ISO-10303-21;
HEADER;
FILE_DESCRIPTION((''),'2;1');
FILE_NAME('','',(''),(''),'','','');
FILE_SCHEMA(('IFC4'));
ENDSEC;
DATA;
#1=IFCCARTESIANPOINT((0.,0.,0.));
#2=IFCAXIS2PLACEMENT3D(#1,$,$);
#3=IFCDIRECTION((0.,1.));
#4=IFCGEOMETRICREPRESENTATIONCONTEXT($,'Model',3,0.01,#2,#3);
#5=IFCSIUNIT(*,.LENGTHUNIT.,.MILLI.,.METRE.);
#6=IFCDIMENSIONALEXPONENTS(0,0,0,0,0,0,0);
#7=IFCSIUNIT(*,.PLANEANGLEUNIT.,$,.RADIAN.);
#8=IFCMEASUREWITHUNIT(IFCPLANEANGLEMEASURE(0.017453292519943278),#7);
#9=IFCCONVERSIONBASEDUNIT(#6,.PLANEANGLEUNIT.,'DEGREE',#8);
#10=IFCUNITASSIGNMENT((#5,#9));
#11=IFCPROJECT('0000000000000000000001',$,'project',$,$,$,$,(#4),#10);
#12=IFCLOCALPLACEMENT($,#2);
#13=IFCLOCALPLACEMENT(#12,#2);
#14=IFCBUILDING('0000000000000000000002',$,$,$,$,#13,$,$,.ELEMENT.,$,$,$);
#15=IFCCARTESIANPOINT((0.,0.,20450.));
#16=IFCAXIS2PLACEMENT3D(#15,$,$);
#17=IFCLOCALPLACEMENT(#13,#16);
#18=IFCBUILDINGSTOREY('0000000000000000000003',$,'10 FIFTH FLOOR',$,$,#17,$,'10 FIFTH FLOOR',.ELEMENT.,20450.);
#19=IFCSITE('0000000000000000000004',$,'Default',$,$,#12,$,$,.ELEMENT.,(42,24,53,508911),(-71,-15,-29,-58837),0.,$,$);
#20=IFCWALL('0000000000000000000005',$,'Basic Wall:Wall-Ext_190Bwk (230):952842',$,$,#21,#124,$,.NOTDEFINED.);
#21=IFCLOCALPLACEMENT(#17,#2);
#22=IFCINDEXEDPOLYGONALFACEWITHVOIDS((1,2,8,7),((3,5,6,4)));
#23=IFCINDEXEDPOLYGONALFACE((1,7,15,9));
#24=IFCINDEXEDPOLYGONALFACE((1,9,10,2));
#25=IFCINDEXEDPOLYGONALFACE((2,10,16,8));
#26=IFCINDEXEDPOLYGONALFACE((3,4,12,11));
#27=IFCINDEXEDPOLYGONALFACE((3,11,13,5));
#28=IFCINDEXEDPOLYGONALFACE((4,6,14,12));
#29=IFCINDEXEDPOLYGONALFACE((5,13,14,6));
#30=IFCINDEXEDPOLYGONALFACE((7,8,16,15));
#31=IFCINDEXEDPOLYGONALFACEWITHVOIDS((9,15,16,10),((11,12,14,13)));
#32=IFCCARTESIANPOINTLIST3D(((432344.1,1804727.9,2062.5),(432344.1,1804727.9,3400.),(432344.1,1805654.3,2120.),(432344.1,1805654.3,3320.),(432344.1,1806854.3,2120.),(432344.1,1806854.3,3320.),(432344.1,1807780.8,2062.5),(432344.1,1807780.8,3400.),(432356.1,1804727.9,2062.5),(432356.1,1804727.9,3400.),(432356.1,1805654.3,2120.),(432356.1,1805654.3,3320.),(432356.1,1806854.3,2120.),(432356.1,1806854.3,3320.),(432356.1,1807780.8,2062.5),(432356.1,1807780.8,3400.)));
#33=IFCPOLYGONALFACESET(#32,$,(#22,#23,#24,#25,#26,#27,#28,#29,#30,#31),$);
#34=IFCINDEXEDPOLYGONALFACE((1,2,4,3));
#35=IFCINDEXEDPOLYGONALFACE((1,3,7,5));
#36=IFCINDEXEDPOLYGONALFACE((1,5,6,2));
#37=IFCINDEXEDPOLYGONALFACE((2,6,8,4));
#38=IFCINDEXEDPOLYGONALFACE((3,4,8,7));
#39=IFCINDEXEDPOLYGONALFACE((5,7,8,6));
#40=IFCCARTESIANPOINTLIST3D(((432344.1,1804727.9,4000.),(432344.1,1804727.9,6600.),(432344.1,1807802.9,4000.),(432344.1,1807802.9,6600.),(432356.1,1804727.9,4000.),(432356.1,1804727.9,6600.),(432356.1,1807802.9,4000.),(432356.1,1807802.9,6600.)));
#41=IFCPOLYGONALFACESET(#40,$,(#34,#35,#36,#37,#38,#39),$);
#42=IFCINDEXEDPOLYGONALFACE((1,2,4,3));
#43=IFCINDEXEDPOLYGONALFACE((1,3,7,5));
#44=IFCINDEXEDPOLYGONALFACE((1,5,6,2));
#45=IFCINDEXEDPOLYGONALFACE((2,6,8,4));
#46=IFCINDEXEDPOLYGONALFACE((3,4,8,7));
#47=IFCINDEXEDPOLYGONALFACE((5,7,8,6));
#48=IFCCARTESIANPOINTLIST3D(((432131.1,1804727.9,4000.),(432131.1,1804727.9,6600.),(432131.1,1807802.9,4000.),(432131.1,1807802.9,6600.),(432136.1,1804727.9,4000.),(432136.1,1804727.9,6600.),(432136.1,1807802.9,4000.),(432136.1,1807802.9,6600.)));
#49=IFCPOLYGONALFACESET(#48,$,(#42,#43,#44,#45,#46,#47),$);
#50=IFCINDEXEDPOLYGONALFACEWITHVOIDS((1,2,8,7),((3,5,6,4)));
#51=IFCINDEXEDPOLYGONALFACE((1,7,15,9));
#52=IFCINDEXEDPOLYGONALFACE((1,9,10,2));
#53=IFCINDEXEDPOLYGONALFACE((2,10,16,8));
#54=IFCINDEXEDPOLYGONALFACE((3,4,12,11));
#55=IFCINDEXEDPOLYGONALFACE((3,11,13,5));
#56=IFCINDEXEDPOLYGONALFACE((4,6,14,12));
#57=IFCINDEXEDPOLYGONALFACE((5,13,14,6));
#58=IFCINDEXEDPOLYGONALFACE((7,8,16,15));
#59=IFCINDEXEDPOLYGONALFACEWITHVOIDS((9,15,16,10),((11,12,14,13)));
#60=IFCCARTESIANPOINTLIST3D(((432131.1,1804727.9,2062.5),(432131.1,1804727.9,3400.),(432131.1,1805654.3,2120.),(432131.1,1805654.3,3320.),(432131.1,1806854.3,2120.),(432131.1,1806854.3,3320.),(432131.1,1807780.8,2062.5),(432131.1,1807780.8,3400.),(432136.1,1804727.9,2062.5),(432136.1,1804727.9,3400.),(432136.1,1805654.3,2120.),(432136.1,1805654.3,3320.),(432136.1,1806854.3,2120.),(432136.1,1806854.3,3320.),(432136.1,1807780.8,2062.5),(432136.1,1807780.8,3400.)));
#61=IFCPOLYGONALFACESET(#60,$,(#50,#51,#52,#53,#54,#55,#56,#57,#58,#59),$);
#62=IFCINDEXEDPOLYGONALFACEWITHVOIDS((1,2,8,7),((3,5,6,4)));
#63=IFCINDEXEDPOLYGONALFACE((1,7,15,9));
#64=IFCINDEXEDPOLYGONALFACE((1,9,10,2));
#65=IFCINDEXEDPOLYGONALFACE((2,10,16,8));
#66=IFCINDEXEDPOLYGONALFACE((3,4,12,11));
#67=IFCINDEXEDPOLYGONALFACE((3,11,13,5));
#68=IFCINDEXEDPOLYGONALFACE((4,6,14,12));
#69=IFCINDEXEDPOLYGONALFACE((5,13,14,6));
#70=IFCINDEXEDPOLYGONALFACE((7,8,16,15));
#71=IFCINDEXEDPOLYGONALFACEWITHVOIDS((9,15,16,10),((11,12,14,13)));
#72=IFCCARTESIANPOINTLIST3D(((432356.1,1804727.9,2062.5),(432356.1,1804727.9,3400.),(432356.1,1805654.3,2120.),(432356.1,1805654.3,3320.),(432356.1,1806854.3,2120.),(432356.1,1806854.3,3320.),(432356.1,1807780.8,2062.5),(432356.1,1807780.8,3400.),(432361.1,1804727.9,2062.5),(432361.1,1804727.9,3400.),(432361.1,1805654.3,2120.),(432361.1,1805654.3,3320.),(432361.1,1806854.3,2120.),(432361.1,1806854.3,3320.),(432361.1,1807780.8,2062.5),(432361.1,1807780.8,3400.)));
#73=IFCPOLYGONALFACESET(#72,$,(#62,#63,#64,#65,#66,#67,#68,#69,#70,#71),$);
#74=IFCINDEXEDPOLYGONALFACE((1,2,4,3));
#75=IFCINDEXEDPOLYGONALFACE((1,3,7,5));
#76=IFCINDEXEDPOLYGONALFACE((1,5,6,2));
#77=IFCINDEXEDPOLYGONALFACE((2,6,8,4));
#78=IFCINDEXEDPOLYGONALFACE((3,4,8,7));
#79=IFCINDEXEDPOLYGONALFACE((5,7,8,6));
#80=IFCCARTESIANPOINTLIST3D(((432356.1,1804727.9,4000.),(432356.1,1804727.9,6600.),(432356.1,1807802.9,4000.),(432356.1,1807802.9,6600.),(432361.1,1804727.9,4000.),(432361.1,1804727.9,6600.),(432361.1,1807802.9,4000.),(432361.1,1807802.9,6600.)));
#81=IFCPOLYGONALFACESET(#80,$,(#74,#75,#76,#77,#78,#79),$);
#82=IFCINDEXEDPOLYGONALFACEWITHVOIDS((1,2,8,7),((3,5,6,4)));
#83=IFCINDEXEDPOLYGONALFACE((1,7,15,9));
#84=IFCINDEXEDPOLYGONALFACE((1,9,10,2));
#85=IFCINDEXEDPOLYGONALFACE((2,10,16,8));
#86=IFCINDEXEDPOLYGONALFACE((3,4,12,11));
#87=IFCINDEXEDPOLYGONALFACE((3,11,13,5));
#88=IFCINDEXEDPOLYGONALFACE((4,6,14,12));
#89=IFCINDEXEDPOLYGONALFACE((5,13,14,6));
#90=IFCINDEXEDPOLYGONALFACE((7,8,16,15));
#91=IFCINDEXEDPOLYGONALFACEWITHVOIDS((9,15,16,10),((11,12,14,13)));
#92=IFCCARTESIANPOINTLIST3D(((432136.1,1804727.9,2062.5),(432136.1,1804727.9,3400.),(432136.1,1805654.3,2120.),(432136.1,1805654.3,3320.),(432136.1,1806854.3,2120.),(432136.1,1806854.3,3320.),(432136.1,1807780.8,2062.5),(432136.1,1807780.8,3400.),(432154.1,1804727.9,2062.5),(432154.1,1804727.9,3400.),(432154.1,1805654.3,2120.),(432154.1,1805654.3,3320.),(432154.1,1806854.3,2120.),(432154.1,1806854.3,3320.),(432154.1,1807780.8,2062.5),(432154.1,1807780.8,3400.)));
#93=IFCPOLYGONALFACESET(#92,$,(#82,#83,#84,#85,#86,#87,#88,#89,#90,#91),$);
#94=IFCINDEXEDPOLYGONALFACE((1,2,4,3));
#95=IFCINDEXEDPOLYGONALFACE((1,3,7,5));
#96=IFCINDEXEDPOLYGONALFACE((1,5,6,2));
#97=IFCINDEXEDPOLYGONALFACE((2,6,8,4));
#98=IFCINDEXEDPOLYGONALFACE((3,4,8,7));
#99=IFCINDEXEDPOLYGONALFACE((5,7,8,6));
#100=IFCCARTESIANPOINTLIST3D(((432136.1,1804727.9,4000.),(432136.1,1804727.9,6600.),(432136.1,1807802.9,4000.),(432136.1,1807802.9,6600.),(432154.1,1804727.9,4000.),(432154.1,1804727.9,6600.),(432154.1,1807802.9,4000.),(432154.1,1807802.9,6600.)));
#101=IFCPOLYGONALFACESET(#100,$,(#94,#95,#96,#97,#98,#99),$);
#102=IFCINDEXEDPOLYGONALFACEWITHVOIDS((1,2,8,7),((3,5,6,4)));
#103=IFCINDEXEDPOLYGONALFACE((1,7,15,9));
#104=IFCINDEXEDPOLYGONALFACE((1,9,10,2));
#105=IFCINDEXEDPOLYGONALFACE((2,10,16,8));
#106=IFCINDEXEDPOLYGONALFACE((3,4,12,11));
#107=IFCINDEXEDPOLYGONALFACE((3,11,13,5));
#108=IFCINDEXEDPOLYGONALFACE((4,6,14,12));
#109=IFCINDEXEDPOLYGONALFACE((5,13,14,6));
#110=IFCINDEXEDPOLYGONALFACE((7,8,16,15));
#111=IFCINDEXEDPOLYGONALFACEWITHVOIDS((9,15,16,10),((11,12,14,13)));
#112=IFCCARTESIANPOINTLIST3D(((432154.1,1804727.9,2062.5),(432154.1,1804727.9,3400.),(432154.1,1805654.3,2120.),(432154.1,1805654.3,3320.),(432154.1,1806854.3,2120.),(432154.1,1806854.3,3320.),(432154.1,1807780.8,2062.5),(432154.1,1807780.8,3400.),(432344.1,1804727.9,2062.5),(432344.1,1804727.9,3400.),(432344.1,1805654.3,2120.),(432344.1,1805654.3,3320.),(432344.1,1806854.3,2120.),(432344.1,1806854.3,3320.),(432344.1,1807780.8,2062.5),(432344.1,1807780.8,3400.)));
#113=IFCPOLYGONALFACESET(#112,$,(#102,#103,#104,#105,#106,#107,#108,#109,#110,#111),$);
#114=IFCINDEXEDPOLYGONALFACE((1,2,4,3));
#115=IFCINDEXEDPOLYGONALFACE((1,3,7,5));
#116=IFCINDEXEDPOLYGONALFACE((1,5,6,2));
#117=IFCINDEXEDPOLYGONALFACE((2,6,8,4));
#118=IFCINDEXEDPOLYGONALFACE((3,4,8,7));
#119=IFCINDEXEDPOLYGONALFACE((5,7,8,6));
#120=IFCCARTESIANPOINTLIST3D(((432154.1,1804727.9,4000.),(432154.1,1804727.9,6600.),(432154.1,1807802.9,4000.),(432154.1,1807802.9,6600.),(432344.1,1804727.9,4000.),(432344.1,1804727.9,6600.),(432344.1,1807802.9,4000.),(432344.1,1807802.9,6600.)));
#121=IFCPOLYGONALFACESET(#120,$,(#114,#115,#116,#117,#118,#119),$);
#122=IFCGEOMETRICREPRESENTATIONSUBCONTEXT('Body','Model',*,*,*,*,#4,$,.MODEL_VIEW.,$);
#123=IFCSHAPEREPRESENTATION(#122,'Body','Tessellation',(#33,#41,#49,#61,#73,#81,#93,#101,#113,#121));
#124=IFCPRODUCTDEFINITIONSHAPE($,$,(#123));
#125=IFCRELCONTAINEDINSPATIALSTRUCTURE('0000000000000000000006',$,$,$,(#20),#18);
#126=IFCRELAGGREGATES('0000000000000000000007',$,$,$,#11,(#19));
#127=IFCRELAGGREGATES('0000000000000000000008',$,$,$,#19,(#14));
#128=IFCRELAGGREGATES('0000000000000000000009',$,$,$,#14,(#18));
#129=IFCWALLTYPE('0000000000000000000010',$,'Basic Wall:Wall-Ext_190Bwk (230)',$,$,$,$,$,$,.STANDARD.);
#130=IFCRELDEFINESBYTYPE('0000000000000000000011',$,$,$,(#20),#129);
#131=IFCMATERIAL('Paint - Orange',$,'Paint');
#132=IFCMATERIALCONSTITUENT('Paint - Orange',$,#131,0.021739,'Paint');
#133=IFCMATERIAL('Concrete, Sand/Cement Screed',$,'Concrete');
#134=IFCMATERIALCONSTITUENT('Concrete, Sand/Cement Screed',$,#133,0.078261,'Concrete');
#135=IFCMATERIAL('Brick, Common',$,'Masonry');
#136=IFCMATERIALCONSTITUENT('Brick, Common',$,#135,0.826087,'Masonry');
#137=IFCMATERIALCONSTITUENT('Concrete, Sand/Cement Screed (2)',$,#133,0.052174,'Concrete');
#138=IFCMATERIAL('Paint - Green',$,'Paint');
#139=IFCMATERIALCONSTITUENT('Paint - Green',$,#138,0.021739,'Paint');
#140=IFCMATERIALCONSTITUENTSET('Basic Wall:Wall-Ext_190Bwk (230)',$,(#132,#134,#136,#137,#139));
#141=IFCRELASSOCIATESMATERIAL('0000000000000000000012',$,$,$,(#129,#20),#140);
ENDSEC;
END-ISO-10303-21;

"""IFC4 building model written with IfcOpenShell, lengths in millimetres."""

from ifc_helpers import new_model, entity, si_unit, converted_unit, direction, frame, origin, place, context, subcontext, project, spatial, indexed_curve, outline, extrude, material, constituent, constituent_set, type_object, element, save


model = new_model("IFC4")

# Units and contexts
model_context = context("Model", 3, precision=0.01, world=origin(), true_north=direction((0.0, 1.0)))
body_context = subcontext(model_context, "Body", "Model", "MODEL_VIEW")
ifc_project = project(units=[si_unit("LENGTHUNIT", "METRE", prefix="MILLI"), converted_unit("PLANEANGLEUNIT", "DEGREE", entity("IfcPlaneAngleMeasure", 0.017453292519943278), si_unit("PLANEANGLEUNIT", "RADIAN"), dimensions=[0, 0, 0, 0, 0, 0, 0])], contexts=[model_context])

# Site, building, storey
site_placement = place(None, origin())
site = spatial("IfcSite", under=ifc_project, at=site_placement, Name="Default", CompositionType="ELEMENT", RefLatitude=(42, 24, 53, 508911), RefLongitude=(-71, -15, -29, -58837), RefElevation=0.0)
building_placement = place(site_placement, origin())
building = spatial("IfcBuilding", under=site, at=building_placement, CompositionType="ELEMENT")
storey_placement = place(building_placement, frame((0.0, 0.0, 20450.0)))
storey = spatial("IfcBuildingStorey", under=building, at=storey_placement, Name="10 FIFTH FLOOR", LongName="10 FIFTH FLOOR", CompositionType="ELEMENT", Elevation=20450.0)

# Shared definitions
ifc_material_1 = material(Name="Concrete, Sand/Cement Screed", Category="Concrete")
ifc_material_2 = material(Name="Brick, Common", Category="Masonry")

# Wall, opening
ifc_material_3 = material(Name="Paint - Orange", Category="Paint")
ifc_constituent_1 = constituent(ifc_material_3, Name="Paint - Orange", Category="Paint", fraction=0.021739)
ifc_constituent_2 = constituent(ifc_material_1, Name="Concrete, Sand/Cement Screed", Category="Concrete", fraction=0.078261)
ifc_constituent_3 = constituent(ifc_material_2, Name="Brick, Common", Category="Masonry", fraction=0.826087)
ifc_constituent_4 = constituent(ifc_material_1, Name="Concrete, Sand/Cement Screed (2)", Category="Concrete", fraction=0.052174)
ifc_material_4 = material(Name="Paint - Green", Category="Paint")
ifc_constituent_5 = constituent(ifc_material_4, Name="Paint - Green", Category="Paint", fraction=0.021739)
ifc_constituent_set_1 = constituent_set(constituents=[ifc_constituent_1, ifc_constituent_2, ifc_constituent_3, ifc_constituent_4, ifc_constituent_5], Name="Basic Wall:Wall-Ext_190Bwk (230)")
wall_type_1 = type_object("IfcWallType", Name="Basic Wall:Wall-Ext_190Bwk (230)", PredefinedType="STANDARD", material=ifc_constituent_set_1)
wall_1_placement = place(storey_placement, frame((432246.1, 1804727.9, 2062.5), z_axis=(0.0, 0.0, 1.0), x_axis=(0.0, 1.0, 0.0)))
wall_1 = element("IfcWall", 1, at=wall_1_placement, inside=storey, type_object=wall_type_1, material=ifc_constituent_set_1, Name="Basic Wall:Wall-Ext_190Bwk (230):952842", PredefinedType="NOTDEFINED", context=body_context, shape_type="SweptSolid", body=[
    extrude(outline(indexed_curve([(-668.8, -1526.4), (668.8, -1526.4), (668.8, 1526.4), (-668.8, 1526.4), (-668.8, -1526.4)], self_intersect=False), holes=[indexed_curve([(588.8, 600.0), (588.8, -600.0), (-611.2, -600.0), (-611.2, 600.0), (588.8, 600.0)], self_intersect=False)]), frame((1526.4, -98.0, 668.8), z_axis=(0.0, -1.0, 0.0), x_axis=(0.0, 0.0, 1.0)), (0.0, 0.0, 1.0), 12.0),
    extrude(outline(indexed_curve([(-1537.5, -6.0), (1537.5, -6.0), (1537.5, 6.0), (-1537.5, 6.0), (-1537.5, -6.0)], self_intersect=False)), frame((1537.5, -104.0, 1937.5)), (0.0, 0.0, 1.0), 2600.0),
    extrude(outline(indexed_curve([(-2.5, -1537.5), (2.5, -1537.5), (2.5, 1537.5), (-2.5, 1537.5), (-2.5, -1537.5)], self_intersect=False)), frame((1537.5, 112.5, 1937.5), z_axis=(0.0, 0.0, 1.0), x_axis=(0.0, -1.0, 0.0)), (0.0, 0.0, 1.0), 2600.0),
    extrude(outline(indexed_curve([(-1526.4, -668.8), (1526.4, -668.8), (1526.4, 668.8), (-1526.4, 668.8), (-1526.4, -668.8)], self_intersect=False), holes=[indexed_curve([(-600.0, 588.8), (600.0, 588.8), (600.0, -611.2), (-600.0, -611.2), (-600.0, 588.8)], self_intersect=False)]), frame((1526.4, 115.0, 668.8), z_axis=(0.0, -1.0, 0.0), x_axis=(1.0, 0.0, 0.0)), (0.0, 0.0, 1.0), 5.0),
    extrude(outline(indexed_curve([(-668.8, -1526.4), (668.8, -1526.4), (668.8, 1526.4), (-668.8, 1526.4), (-668.8, -1526.4)], self_intersect=False), holes=[indexed_curve([(588.8, 600.0), (588.8, -600.0), (-611.2, -600.0), (-611.2, 600.0), (588.8, 600.0)], self_intersect=False)]), frame((1526.4, -110.0, 668.8), z_axis=(0.0, -1.0, 0.0), x_axis=(0.0, 0.0, 1.0)), (0.0, 0.0, 1.0), 5.0),
    extrude(outline(indexed_curve([(-2.5, -1537.5), (2.5, -1537.5), (2.5, 1537.5), (-2.5, 1537.5), (-2.5, -1537.5)], self_intersect=False)), frame((1537.5, -112.5, 1937.5), z_axis=(0.0, 0.0, 1.0), x_axis=(0.0, 1.0, 0.0)), (0.0, 0.0, 1.0), 2600.0),
    extrude(outline(indexed_curve([(-668.8, -1526.4), (668.8, -1526.4), (668.8, 1526.4), (-668.8, 1526.4), (-668.8, -1526.4)], self_intersect=False), holes=[indexed_curve([(588.8, 600.0), (588.8, -600.0), (-611.2, -600.0), (-611.2, 600.0), (588.8, 600.0)], self_intersect=False)]), frame((1526.4, 110.0, 668.8), z_axis=(0.0, -1.0, 0.0), x_axis=(0.0, 0.0, 1.0)), (0.0, 0.0, 1.0), 18.0),
    extrude(outline(indexed_curve([(-1537.5, -9.0), (1537.5, -9.0), (1537.5, 9.0), (-1537.5, 9.0), (-1537.5, -9.0)], self_intersect=False)), frame((1537.5, 101.0, 1937.5)), (0.0, 0.0, 1.0), 2600.0),
    extrude(outline(indexed_curve([(-668.8, -1526.4), (668.8, -1526.4), (668.8, 1526.4), (-668.8, 1526.4), (-668.8, -1526.4)], self_intersect=False), holes=[indexed_curve([(588.8, 600.0), (588.8, -600.0), (-611.2, -600.0), (-611.2, 600.0), (588.8, 600.0)], self_intersect=False)]), frame((1526.4, 92.0, 668.8), z_axis=(0.0, -1.0, 0.0), x_axis=(0.0, 0.0, 1.0)), (0.0, 0.0, 1.0), 190.0),
    extrude(outline(indexed_curve([(-1537.5, -95.0), (1537.5, -95.0), (1537.5, 95.0), (-1537.5, 95.0), (-1537.5, -95.0)], self_intersect=False)), frame((1537.5, -3.0, 1937.5)), (0.0, 0.0, 1.0), 2600.0),
])
opening_1_placement = place(wall_1_placement, frame((926.4, -115.0, 57.5)))
element("IfcOpeningElement", 2, at=opening_1_placement, cuts=wall_1, PredefinedType="OPENING", context=body_context, shape_type="SweptSolid", body=[
    extrude(outline(indexed_curve([(1200.0, 0.0), (1200.0, 1200.0), (0.0, 1200.0), (0.0, 0.0), (1200.0, 0.0)], self_intersect=False)), frame((0.0, 0.0, 0.0), z_axis=(0.0, 1.0, 0.0), x_axis=(0.0, 0.0, 1.0)), (0.0, 0.0, 1.0), 230.0),
])

save(model, "model.ifc")
